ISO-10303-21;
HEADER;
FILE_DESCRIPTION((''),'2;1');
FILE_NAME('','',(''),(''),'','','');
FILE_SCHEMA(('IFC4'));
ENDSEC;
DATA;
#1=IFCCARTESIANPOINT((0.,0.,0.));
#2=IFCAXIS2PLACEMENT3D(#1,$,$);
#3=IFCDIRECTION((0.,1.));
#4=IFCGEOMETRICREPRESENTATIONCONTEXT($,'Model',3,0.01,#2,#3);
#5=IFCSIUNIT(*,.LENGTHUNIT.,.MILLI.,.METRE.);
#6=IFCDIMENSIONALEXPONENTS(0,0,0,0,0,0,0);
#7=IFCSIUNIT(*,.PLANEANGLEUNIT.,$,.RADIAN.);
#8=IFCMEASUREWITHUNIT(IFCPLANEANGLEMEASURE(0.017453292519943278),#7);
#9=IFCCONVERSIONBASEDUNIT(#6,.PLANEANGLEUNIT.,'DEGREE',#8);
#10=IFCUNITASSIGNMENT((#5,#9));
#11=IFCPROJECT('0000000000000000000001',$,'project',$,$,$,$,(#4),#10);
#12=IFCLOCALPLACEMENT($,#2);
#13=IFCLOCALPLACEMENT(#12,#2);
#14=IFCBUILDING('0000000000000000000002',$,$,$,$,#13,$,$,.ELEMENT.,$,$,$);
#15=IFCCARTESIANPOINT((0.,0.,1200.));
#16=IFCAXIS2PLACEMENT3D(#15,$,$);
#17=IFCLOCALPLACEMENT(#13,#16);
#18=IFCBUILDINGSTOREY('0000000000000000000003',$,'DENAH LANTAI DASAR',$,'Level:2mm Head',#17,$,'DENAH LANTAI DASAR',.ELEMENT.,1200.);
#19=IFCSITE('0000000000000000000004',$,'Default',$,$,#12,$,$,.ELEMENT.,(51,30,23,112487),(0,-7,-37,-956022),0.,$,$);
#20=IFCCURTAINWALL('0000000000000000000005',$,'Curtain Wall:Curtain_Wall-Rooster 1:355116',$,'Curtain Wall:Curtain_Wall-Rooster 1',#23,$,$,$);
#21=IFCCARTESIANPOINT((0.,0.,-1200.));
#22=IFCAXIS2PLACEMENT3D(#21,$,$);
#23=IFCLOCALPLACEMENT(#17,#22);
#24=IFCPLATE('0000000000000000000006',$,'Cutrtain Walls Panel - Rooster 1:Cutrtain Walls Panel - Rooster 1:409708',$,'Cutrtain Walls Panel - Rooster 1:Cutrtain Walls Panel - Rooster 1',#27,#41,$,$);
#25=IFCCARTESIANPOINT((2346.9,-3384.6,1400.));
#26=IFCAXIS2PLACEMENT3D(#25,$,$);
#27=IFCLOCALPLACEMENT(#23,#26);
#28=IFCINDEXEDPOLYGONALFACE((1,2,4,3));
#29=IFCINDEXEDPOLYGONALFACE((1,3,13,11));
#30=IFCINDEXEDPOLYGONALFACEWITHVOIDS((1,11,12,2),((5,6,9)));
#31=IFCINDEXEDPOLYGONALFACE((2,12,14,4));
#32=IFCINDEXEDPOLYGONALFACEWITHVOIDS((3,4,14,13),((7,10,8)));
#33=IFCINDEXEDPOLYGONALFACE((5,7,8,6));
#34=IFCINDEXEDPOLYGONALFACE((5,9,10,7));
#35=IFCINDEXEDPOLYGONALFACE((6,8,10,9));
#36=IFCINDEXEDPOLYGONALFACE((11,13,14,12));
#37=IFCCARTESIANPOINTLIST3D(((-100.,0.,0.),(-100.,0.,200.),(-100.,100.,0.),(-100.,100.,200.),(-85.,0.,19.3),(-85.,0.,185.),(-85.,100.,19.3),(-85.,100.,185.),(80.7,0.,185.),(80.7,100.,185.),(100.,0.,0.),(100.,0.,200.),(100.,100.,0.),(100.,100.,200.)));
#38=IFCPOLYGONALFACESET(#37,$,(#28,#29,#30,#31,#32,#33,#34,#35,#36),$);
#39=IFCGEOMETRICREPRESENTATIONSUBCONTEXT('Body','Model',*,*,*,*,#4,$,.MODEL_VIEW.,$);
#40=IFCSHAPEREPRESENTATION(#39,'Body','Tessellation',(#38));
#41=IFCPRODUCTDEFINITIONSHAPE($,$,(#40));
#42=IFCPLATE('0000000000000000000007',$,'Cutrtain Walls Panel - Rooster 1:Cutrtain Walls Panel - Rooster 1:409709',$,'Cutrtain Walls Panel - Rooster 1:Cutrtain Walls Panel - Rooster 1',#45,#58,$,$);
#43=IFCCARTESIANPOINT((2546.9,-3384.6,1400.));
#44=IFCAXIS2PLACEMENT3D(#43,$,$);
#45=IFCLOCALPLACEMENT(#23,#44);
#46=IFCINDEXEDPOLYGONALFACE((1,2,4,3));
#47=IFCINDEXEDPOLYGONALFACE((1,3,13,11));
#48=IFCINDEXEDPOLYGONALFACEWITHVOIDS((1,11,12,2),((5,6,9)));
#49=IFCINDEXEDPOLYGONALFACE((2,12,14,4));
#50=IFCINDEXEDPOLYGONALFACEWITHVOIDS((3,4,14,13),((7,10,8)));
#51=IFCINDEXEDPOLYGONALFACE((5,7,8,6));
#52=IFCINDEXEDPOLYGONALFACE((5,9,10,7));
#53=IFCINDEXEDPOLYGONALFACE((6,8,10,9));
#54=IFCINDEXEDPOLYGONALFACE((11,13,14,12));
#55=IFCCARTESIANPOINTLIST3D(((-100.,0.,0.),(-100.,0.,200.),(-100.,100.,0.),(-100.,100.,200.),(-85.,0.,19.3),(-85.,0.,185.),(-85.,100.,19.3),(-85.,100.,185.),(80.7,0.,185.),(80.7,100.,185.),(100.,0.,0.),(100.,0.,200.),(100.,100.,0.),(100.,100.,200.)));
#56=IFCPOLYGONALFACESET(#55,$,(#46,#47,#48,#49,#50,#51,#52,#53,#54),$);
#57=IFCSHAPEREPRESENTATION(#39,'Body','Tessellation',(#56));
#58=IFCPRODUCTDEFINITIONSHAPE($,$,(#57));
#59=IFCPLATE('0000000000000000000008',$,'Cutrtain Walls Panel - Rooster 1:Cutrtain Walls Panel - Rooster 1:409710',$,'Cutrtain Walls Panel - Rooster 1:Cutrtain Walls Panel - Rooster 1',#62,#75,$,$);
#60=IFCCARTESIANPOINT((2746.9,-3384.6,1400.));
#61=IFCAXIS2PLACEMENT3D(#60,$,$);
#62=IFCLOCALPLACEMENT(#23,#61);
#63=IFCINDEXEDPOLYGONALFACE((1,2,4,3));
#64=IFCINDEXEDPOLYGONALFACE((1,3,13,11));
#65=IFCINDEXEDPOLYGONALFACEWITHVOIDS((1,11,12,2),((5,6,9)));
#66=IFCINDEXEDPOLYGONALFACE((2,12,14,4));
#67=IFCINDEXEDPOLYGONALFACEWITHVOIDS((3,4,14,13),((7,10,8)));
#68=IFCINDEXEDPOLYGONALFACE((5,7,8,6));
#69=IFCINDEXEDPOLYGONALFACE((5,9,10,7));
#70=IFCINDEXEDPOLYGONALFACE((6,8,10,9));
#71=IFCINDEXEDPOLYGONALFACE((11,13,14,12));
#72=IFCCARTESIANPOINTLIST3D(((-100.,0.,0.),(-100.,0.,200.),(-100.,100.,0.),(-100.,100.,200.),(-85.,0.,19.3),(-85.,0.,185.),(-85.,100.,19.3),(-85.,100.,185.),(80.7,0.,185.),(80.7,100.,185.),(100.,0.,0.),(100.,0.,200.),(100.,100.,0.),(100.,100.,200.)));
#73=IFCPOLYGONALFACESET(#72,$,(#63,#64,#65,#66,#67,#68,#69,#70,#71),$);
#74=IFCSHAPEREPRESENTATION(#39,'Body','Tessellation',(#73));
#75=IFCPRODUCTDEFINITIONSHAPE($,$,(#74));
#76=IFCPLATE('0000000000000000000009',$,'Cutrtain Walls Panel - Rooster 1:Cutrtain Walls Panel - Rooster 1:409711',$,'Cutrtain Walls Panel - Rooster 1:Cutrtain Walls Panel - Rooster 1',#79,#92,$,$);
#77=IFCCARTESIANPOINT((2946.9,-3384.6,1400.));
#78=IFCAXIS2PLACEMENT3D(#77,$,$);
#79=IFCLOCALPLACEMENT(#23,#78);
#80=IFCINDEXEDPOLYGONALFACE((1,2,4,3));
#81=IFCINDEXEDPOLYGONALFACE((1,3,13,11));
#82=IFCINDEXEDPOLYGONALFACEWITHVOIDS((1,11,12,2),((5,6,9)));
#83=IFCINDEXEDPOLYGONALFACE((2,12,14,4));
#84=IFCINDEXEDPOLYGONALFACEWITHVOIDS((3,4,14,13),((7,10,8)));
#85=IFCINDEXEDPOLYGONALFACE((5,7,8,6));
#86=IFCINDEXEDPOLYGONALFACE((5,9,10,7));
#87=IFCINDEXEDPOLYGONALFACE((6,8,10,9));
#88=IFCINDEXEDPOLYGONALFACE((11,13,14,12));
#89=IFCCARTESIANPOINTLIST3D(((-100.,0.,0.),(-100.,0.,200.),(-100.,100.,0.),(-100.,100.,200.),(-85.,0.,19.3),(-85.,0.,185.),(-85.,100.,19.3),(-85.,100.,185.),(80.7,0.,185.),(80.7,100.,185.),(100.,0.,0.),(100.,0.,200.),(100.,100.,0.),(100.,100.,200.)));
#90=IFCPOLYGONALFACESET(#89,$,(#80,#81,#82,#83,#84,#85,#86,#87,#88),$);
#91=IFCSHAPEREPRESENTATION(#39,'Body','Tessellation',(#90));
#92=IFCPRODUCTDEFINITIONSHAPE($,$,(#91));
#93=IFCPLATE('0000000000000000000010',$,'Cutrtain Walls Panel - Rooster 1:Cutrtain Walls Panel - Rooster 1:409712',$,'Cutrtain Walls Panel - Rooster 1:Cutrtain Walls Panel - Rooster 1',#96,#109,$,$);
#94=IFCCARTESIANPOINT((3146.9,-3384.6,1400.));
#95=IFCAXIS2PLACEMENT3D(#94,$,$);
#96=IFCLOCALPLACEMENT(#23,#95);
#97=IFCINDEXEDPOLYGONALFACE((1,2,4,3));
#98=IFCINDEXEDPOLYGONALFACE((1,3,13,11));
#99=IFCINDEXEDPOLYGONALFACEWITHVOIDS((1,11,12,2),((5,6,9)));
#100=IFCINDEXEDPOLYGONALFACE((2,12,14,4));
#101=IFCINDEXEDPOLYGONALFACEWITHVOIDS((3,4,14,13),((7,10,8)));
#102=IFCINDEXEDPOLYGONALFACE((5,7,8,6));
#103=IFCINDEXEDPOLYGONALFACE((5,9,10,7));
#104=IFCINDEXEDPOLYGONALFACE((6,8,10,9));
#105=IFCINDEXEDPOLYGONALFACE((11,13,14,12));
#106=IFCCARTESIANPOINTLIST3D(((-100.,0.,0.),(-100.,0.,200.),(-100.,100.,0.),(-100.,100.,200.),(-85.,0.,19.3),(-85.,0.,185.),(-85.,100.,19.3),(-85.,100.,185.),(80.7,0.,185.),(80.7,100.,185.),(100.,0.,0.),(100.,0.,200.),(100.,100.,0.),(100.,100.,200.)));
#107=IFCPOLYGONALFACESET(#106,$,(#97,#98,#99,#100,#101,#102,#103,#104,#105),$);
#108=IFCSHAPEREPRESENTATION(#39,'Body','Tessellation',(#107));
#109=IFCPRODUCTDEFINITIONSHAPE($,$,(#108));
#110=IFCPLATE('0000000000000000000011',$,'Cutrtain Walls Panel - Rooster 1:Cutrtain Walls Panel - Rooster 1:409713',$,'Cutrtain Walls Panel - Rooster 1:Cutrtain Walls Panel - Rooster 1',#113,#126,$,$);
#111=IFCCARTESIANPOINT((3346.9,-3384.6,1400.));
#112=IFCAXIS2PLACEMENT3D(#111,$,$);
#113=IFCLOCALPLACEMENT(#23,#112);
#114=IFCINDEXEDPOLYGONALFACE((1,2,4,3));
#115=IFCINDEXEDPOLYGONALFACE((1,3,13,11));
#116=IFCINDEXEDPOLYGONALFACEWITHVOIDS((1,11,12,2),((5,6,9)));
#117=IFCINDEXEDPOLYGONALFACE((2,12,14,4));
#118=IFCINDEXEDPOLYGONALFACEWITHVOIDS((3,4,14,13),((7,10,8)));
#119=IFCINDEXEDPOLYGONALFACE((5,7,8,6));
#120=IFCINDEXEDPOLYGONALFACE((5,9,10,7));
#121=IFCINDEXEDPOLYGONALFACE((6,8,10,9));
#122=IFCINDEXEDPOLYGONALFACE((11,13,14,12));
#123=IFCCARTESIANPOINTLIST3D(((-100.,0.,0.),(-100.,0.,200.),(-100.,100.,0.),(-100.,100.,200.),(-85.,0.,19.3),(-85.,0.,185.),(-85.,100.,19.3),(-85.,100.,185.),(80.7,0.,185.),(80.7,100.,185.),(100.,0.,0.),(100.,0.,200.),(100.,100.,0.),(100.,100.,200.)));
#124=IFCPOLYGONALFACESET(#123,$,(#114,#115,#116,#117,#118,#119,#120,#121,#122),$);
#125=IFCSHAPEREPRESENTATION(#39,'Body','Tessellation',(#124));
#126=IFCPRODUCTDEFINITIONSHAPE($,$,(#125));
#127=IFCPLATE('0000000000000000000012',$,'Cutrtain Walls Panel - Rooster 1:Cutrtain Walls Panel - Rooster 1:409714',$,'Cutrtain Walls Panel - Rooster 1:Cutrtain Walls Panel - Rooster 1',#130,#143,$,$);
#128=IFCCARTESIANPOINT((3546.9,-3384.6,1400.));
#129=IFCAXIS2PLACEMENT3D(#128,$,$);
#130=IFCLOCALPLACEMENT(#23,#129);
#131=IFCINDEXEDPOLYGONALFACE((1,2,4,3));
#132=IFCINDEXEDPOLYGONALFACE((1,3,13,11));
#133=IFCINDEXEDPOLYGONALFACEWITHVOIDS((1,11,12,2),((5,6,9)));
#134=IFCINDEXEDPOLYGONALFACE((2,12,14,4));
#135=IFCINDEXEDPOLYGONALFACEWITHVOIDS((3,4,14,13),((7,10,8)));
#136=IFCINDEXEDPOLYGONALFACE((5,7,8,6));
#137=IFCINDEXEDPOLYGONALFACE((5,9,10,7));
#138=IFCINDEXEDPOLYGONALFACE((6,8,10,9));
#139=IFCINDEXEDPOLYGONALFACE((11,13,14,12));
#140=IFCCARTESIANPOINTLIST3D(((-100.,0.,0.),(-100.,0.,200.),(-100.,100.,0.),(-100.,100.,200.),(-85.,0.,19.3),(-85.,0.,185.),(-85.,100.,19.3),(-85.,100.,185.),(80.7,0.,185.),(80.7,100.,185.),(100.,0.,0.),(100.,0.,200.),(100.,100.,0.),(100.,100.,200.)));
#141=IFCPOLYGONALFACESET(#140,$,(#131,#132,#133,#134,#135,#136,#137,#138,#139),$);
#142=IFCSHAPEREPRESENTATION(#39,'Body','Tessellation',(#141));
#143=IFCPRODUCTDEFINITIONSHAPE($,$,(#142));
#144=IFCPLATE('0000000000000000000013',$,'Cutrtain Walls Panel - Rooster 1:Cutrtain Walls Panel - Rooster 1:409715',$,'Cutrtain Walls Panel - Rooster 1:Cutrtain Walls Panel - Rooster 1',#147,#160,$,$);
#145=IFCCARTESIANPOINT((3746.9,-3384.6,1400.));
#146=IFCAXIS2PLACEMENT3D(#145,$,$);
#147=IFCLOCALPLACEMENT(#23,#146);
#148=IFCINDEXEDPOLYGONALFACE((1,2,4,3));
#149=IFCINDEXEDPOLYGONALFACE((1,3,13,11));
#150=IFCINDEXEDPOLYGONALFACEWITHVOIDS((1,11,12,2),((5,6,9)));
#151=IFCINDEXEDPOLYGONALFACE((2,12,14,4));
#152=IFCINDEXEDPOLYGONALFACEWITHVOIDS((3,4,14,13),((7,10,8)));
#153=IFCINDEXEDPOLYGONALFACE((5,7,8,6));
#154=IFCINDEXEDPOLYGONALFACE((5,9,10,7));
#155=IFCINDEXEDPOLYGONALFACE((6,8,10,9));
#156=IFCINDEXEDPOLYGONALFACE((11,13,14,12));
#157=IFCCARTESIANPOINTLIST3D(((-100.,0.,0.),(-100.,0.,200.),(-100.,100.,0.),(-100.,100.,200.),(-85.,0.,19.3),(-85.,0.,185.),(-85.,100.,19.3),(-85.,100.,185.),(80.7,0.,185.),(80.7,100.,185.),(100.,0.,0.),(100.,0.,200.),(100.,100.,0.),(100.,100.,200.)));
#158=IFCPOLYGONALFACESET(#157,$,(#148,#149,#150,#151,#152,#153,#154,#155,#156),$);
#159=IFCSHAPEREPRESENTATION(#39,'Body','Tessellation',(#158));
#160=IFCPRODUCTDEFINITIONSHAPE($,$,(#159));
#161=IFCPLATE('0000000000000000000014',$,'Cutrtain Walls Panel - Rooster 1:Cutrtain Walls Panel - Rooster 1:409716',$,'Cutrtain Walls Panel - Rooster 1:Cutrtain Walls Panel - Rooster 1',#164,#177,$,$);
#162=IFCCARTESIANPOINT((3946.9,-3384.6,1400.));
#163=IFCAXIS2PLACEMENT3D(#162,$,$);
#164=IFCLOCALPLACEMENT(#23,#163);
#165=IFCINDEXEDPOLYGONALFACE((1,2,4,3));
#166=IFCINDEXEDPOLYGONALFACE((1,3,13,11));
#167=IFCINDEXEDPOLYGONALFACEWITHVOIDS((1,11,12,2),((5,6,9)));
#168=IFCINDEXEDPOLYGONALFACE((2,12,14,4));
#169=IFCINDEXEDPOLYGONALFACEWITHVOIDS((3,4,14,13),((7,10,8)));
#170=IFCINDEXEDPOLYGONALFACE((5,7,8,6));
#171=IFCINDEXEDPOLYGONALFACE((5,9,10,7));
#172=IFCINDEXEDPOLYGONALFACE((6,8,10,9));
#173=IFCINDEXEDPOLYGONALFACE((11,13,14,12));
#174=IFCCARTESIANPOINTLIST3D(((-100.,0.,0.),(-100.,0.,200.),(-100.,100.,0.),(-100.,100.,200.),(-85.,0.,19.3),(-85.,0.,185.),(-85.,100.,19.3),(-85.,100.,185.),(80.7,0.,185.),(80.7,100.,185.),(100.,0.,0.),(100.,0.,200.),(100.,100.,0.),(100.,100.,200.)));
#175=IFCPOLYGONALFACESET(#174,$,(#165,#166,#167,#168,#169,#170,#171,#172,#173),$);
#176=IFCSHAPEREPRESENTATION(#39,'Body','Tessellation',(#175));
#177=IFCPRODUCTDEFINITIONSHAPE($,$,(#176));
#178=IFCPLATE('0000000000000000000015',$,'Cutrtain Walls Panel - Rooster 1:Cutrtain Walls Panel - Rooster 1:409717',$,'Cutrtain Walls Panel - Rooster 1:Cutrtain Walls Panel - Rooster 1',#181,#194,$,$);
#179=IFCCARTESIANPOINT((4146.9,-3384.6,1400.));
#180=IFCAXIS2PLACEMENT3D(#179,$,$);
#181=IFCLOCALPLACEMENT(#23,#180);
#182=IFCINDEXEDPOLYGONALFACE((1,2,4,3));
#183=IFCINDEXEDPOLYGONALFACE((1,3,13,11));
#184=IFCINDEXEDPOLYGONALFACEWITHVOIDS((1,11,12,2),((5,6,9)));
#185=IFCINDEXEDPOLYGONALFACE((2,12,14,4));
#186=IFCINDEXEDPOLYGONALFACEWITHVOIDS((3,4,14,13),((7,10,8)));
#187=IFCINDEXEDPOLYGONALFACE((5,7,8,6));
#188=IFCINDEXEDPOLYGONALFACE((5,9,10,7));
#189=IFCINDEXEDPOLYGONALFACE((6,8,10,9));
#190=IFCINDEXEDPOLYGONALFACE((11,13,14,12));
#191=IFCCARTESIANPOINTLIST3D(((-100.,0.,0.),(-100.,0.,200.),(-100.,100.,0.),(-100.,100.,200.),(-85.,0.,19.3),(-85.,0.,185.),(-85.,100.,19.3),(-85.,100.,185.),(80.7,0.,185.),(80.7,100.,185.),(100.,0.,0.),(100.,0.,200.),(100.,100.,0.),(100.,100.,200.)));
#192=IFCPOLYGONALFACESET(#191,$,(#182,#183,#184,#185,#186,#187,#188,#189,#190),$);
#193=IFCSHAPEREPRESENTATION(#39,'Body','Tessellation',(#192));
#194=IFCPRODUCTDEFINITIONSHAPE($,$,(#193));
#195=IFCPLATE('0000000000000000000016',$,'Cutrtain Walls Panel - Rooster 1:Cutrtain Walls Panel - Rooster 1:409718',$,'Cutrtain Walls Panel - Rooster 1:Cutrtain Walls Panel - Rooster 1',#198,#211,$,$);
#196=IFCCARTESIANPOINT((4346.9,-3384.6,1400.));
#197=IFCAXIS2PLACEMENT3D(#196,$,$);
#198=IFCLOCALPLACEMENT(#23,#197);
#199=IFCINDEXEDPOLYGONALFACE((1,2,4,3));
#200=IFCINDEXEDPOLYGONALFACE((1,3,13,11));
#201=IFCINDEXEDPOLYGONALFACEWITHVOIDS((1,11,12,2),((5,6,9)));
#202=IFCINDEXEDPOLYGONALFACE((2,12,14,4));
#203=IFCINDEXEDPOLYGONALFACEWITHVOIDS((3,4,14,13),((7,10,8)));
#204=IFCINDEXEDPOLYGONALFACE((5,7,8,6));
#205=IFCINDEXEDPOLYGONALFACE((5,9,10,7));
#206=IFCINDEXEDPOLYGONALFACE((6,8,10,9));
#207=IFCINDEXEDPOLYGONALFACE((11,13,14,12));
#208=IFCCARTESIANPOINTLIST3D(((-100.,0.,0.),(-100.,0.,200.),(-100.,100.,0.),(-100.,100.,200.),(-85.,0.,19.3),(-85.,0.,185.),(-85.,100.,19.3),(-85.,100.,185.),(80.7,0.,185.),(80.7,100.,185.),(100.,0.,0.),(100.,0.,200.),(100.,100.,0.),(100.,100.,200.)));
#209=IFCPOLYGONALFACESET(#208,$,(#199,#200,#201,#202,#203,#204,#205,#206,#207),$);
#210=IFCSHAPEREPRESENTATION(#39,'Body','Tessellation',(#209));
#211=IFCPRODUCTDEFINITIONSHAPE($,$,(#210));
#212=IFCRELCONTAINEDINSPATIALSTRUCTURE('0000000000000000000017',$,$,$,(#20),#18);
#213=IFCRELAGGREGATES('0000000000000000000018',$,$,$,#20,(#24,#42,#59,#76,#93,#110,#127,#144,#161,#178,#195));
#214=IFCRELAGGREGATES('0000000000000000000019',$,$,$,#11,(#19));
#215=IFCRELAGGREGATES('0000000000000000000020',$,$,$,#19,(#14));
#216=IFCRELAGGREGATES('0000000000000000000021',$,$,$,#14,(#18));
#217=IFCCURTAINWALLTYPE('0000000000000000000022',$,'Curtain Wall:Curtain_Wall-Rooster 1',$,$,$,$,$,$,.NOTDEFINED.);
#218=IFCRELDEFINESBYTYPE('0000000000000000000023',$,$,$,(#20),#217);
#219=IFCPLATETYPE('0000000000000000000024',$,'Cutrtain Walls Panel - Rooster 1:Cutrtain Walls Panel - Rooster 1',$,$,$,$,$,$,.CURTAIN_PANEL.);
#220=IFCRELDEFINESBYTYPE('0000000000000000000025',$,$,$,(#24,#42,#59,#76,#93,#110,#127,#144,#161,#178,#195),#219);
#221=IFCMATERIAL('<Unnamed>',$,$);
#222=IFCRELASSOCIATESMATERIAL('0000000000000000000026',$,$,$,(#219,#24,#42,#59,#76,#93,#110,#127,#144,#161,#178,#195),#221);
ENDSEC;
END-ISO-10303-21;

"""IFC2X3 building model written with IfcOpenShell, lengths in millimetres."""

from ifc_helpers import new_model, entity, si_unit, converted_unit, direction, frame, origin, place, context, subcontext, project, spatial, polyline, outline, extrude, source, transform, mapped, material, type_object, type_shapes, element, aggregate, save


model = new_model("IFC2X3")

# Units and contexts
model_context = context("Model", 3, precision=0.01, world=origin(), true_north=direction((0.0, 1.0)))
body_context = subcontext(model_context, "Body", "Model", "MODEL_VIEW")
ifc_project = project(units=[si_unit("LENGTHUNIT", "METRE", prefix="MILLI"), converted_unit("PLANEANGLEUNIT", "DEGREE", entity("IfcPlaneAngleMeasure", 0.017453292519943278), si_unit("PLANEANGLEUNIT", "RADIAN"), dimensions=[0, 0, 0, 0, 0, 0, 0])], contexts=[model_context])

# Site, building, storey
site_placement = place(None, origin())
site = spatial("IfcSite", under=ifc_project, at=site_placement, Name="Default", CompositionType="ELEMENT", RefLatitude=(51, 30, 23, 112487), RefLongitude=(0, -7, -37, -956022), RefElevation=0.0)
building_placement = place(site_placement, origin())
building = spatial("IfcBuilding", under=site, at=building_placement, CompositionType="ELEMENT")
storey_placement = place(building_placement, frame((0.0, 0.0, 1200.0)))
storey = spatial("IfcBuildingStorey", under=building, at=storey_placement, Name="DENAH LANTAI DASAR", ObjectType="Level:2mm Head", LongName="DENAH LANTAI DASAR", CompositionType="ELEMENT", Elevation=1200.0)

# Curtain wall, plates
curtain_wall_type = type_object("IfcCurtainWallType", Name="Curtain Wall:Curtain_Wall-Rooster 1", PredefinedType="NOTDEFINED")
curtain_wall_placement = place(storey_placement, frame((0.0, 0.0, -1200.0)))
curtain_wall = element("IfcCurtainWall", 1, at=curtain_wall_placement, inside=storey, type_object=curtain_wall_type, Name="Curtain Wall:Curtain_Wall-Rooster 1:355116", ObjectType="Curtain Wall:Curtain_Wall-Rooster 1")
ifc_material = material(Name="<Unnamed>")
plate_type_1 = type_object("IfcPlateType", Name="Cutrtain Walls Panel - Rooster 1:Cutrtain Walls Panel - Rooster 1", PredefinedType="CURTAIN_PANEL", material=ifc_material)
shared_shape_1 = source(origin(), body_context, "Body", "SweptSolid", [
    extrude(outline(polyline([(-100.0, -100.0), (100.0, -100.0), (100.0, 100.0), (-100.0, 100.0), (-100.0, -100.0)]), holes=[polyline([(80.7, 85.0), (-85.0, -80.7), (-85.0, 85.0), (80.7, 85.0)])]), frame((0.0, 0.0, 100.0), z_axis=(0.0, 1.0, 0.0), x_axis=(0.0, 0.0, -1.0)), (0.0, 0.0, 1.0), 100.0),
])
type_shapes(plate_type_1, [shared_shape_1])
plate_1_placement = place(curtain_wall_placement, frame((2346.9, -3384.6, 1400.0)))
plate_1 = element("IfcPlate", 2, at=plate_1_placement, type_object=plate_type_1, material=ifc_material, Name="Cutrtain Walls Panel - Rooster 1:Cutrtain Walls Panel - Rooster 1:409708", ObjectType="Cutrtain Walls Panel - Rooster 1:Cutrtain Walls Panel - Rooster 1", context=body_context, shape_type="MappedRepresentation", body=[
    mapped(shared_shape_1, transform((0.0, 0.0, 0.0), scale=1.0)),
])
plate_2_placement = place(curtain_wall_placement, frame((2546.9, -3384.6, 1400.0)))
plate_2 = element("IfcPlate", 3, at=plate_2_placement, type_object=plate_type_1, material=ifc_material, Name="Cutrtain Walls Panel - Rooster 1:Cutrtain Walls Panel - Rooster 1:409709", ObjectType="Cutrtain Walls Panel - Rooster 1:Cutrtain Walls Panel - Rooster 1", context=body_context, shape_type="MappedRepresentation", body=[
    mapped(shared_shape_1, transform((0.0, 0.0, 0.0), scale=1.0)),
])
plate_3_placement = place(curtain_wall_placement, frame((2746.9, -3384.6, 1400.0)))
plate_3 = element("IfcPlate", 4, at=plate_3_placement, type_object=plate_type_1, material=ifc_material, Name="Cutrtain Walls Panel - Rooster 1:Cutrtain Walls Panel - Rooster 1:409710", ObjectType="Cutrtain Walls Panel - Rooster 1:Cutrtain Walls Panel - Rooster 1", context=body_context, shape_type="MappedRepresentation", body=[
    mapped(shared_shape_1, transform((0.0, 0.0, 0.0), scale=1.0)),
])
plate_4_placement = place(curtain_wall_placement, frame((2946.9, -3384.6, 1400.0)))
plate_4 = element("IfcPlate", 5, at=plate_4_placement, type_object=plate_type_1, material=ifc_material, Name="Cutrtain Walls Panel - Rooster 1:Cutrtain Walls Panel - Rooster 1:409711", ObjectType="Cutrtain Walls Panel - Rooster 1:Cutrtain Walls Panel - Rooster 1", context=body_context, shape_type="MappedRepresentation", body=[
    mapped(shared_shape_1, transform((0.0, 0.0, 0.0), scale=1.0)),
])
plate_5_placement = place(curtain_wall_placement, frame((3146.9, -3384.6, 1400.0)))
plate_5 = element("IfcPlate", 6, at=plate_5_placement, type_object=plate_type_1, material=ifc_material, Name="Cutrtain Walls Panel - Rooster 1:Cutrtain Walls Panel - Rooster 1:409712", ObjectType="Cutrtain Walls Panel - Rooster 1:Cutrtain Walls Panel - Rooster 1", context=body_context, shape_type="MappedRepresentation", body=[
    mapped(shared_shape_1, transform((0.0, 0.0, 0.0), scale=1.0)),
])
plate_6_placement = place(curtain_wall_placement, frame((3346.9, -3384.6, 1400.0)))
plate_6 = element("IfcPlate", 7, at=plate_6_placement, type_object=plate_type_1, material=ifc_material, Name="Cutrtain Walls Panel - Rooster 1:Cutrtain Walls Panel - Rooster 1:409713", ObjectType="Cutrtain Walls Panel - Rooster 1:Cutrtain Walls Panel - Rooster 1", context=body_context, shape_type="MappedRepresentation", body=[
    mapped(shared_shape_1, transform((0.0, 0.0, 0.0), scale=1.0)),
])
plate_7_placement = place(curtain_wall_placement, frame((3546.9, -3384.6, 1400.0)))
plate_7 = element("IfcPlate", 8, at=plate_7_placement, type_object=plate_type_1, material=ifc_material, Name="Cutrtain Walls Panel - Rooster 1:Cutrtain Walls Panel - Rooster 1:409714", ObjectType="Cutrtain Walls Panel - Rooster 1:Cutrtain Walls Panel - Rooster 1", context=body_context, shape_type="MappedRepresentation", body=[
    mapped(shared_shape_1, transform((0.0, 0.0, 0.0), scale=1.0)),
])
plate_8_placement = place(curtain_wall_placement, frame((3746.9, -3384.6, 1400.0)))
plate_8 = element("IfcPlate", 9, at=plate_8_placement, type_object=plate_type_1, material=ifc_material, Name="Cutrtain Walls Panel - Rooster 1:Cutrtain Walls Panel - Rooster 1:409715", ObjectType="Cutrtain Walls Panel - Rooster 1:Cutrtain Walls Panel - Rooster 1", context=body_context, shape_type="MappedRepresentation", body=[
    mapped(shared_shape_1, transform((0.0, 0.0, 0.0), scale=1.0)),
])
plate_9_placement = place(curtain_wall_placement, frame((3946.9, -3384.6, 1400.0)))
plate_9 = element("IfcPlate", 10, at=plate_9_placement, type_object=plate_type_1, material=ifc_material, Name="Cutrtain Walls Panel - Rooster 1:Cutrtain Walls Panel - Rooster 1:409716", ObjectType="Cutrtain Walls Panel - Rooster 1:Cutrtain Walls Panel - Rooster 1", context=body_context, shape_type="MappedRepresentation", body=[
    mapped(shared_shape_1, transform((0.0, 0.0, 0.0), scale=1.0)),
])
plate_10_placement = place(curtain_wall_placement, frame((4146.9, -3384.6, 1400.0)))
plate_10 = element("IfcPlate", 11, at=plate_10_placement, type_object=plate_type_1, material=ifc_material, Name="Cutrtain Walls Panel - Rooster 1:Cutrtain Walls Panel - Rooster 1:409717", ObjectType="Cutrtain Walls Panel - Rooster 1:Cutrtain Walls Panel - Rooster 1", context=body_context, shape_type="MappedRepresentation", body=[
    mapped(shared_shape_1, transform((0.0, 0.0, 0.0), scale=1.0)),
])
plate_11_placement = place(curtain_wall_placement, frame((4346.9, -3384.6, 1400.0)))
plate_11 = element("IfcPlate", 12, at=plate_11_placement, type_object=plate_type_1, material=ifc_material, Name="Cutrtain Walls Panel - Rooster 1:Cutrtain Walls Panel - Rooster 1:409718", ObjectType="Cutrtain Walls Panel - Rooster 1:Cutrtain Walls Panel - Rooster 1", context=body_context, shape_type="MappedRepresentation", body=[
    mapped(shared_shape_1, transform((0.0, 0.0, 0.0), scale=1.0)),
])
aggregate(curtain_wall, [plate_1, plate_2, plate_3, plate_4, plate_5, plate_6, plate_7, plate_8, plate_9, plate_10, plate_11])

save(model, "model.ifc")
